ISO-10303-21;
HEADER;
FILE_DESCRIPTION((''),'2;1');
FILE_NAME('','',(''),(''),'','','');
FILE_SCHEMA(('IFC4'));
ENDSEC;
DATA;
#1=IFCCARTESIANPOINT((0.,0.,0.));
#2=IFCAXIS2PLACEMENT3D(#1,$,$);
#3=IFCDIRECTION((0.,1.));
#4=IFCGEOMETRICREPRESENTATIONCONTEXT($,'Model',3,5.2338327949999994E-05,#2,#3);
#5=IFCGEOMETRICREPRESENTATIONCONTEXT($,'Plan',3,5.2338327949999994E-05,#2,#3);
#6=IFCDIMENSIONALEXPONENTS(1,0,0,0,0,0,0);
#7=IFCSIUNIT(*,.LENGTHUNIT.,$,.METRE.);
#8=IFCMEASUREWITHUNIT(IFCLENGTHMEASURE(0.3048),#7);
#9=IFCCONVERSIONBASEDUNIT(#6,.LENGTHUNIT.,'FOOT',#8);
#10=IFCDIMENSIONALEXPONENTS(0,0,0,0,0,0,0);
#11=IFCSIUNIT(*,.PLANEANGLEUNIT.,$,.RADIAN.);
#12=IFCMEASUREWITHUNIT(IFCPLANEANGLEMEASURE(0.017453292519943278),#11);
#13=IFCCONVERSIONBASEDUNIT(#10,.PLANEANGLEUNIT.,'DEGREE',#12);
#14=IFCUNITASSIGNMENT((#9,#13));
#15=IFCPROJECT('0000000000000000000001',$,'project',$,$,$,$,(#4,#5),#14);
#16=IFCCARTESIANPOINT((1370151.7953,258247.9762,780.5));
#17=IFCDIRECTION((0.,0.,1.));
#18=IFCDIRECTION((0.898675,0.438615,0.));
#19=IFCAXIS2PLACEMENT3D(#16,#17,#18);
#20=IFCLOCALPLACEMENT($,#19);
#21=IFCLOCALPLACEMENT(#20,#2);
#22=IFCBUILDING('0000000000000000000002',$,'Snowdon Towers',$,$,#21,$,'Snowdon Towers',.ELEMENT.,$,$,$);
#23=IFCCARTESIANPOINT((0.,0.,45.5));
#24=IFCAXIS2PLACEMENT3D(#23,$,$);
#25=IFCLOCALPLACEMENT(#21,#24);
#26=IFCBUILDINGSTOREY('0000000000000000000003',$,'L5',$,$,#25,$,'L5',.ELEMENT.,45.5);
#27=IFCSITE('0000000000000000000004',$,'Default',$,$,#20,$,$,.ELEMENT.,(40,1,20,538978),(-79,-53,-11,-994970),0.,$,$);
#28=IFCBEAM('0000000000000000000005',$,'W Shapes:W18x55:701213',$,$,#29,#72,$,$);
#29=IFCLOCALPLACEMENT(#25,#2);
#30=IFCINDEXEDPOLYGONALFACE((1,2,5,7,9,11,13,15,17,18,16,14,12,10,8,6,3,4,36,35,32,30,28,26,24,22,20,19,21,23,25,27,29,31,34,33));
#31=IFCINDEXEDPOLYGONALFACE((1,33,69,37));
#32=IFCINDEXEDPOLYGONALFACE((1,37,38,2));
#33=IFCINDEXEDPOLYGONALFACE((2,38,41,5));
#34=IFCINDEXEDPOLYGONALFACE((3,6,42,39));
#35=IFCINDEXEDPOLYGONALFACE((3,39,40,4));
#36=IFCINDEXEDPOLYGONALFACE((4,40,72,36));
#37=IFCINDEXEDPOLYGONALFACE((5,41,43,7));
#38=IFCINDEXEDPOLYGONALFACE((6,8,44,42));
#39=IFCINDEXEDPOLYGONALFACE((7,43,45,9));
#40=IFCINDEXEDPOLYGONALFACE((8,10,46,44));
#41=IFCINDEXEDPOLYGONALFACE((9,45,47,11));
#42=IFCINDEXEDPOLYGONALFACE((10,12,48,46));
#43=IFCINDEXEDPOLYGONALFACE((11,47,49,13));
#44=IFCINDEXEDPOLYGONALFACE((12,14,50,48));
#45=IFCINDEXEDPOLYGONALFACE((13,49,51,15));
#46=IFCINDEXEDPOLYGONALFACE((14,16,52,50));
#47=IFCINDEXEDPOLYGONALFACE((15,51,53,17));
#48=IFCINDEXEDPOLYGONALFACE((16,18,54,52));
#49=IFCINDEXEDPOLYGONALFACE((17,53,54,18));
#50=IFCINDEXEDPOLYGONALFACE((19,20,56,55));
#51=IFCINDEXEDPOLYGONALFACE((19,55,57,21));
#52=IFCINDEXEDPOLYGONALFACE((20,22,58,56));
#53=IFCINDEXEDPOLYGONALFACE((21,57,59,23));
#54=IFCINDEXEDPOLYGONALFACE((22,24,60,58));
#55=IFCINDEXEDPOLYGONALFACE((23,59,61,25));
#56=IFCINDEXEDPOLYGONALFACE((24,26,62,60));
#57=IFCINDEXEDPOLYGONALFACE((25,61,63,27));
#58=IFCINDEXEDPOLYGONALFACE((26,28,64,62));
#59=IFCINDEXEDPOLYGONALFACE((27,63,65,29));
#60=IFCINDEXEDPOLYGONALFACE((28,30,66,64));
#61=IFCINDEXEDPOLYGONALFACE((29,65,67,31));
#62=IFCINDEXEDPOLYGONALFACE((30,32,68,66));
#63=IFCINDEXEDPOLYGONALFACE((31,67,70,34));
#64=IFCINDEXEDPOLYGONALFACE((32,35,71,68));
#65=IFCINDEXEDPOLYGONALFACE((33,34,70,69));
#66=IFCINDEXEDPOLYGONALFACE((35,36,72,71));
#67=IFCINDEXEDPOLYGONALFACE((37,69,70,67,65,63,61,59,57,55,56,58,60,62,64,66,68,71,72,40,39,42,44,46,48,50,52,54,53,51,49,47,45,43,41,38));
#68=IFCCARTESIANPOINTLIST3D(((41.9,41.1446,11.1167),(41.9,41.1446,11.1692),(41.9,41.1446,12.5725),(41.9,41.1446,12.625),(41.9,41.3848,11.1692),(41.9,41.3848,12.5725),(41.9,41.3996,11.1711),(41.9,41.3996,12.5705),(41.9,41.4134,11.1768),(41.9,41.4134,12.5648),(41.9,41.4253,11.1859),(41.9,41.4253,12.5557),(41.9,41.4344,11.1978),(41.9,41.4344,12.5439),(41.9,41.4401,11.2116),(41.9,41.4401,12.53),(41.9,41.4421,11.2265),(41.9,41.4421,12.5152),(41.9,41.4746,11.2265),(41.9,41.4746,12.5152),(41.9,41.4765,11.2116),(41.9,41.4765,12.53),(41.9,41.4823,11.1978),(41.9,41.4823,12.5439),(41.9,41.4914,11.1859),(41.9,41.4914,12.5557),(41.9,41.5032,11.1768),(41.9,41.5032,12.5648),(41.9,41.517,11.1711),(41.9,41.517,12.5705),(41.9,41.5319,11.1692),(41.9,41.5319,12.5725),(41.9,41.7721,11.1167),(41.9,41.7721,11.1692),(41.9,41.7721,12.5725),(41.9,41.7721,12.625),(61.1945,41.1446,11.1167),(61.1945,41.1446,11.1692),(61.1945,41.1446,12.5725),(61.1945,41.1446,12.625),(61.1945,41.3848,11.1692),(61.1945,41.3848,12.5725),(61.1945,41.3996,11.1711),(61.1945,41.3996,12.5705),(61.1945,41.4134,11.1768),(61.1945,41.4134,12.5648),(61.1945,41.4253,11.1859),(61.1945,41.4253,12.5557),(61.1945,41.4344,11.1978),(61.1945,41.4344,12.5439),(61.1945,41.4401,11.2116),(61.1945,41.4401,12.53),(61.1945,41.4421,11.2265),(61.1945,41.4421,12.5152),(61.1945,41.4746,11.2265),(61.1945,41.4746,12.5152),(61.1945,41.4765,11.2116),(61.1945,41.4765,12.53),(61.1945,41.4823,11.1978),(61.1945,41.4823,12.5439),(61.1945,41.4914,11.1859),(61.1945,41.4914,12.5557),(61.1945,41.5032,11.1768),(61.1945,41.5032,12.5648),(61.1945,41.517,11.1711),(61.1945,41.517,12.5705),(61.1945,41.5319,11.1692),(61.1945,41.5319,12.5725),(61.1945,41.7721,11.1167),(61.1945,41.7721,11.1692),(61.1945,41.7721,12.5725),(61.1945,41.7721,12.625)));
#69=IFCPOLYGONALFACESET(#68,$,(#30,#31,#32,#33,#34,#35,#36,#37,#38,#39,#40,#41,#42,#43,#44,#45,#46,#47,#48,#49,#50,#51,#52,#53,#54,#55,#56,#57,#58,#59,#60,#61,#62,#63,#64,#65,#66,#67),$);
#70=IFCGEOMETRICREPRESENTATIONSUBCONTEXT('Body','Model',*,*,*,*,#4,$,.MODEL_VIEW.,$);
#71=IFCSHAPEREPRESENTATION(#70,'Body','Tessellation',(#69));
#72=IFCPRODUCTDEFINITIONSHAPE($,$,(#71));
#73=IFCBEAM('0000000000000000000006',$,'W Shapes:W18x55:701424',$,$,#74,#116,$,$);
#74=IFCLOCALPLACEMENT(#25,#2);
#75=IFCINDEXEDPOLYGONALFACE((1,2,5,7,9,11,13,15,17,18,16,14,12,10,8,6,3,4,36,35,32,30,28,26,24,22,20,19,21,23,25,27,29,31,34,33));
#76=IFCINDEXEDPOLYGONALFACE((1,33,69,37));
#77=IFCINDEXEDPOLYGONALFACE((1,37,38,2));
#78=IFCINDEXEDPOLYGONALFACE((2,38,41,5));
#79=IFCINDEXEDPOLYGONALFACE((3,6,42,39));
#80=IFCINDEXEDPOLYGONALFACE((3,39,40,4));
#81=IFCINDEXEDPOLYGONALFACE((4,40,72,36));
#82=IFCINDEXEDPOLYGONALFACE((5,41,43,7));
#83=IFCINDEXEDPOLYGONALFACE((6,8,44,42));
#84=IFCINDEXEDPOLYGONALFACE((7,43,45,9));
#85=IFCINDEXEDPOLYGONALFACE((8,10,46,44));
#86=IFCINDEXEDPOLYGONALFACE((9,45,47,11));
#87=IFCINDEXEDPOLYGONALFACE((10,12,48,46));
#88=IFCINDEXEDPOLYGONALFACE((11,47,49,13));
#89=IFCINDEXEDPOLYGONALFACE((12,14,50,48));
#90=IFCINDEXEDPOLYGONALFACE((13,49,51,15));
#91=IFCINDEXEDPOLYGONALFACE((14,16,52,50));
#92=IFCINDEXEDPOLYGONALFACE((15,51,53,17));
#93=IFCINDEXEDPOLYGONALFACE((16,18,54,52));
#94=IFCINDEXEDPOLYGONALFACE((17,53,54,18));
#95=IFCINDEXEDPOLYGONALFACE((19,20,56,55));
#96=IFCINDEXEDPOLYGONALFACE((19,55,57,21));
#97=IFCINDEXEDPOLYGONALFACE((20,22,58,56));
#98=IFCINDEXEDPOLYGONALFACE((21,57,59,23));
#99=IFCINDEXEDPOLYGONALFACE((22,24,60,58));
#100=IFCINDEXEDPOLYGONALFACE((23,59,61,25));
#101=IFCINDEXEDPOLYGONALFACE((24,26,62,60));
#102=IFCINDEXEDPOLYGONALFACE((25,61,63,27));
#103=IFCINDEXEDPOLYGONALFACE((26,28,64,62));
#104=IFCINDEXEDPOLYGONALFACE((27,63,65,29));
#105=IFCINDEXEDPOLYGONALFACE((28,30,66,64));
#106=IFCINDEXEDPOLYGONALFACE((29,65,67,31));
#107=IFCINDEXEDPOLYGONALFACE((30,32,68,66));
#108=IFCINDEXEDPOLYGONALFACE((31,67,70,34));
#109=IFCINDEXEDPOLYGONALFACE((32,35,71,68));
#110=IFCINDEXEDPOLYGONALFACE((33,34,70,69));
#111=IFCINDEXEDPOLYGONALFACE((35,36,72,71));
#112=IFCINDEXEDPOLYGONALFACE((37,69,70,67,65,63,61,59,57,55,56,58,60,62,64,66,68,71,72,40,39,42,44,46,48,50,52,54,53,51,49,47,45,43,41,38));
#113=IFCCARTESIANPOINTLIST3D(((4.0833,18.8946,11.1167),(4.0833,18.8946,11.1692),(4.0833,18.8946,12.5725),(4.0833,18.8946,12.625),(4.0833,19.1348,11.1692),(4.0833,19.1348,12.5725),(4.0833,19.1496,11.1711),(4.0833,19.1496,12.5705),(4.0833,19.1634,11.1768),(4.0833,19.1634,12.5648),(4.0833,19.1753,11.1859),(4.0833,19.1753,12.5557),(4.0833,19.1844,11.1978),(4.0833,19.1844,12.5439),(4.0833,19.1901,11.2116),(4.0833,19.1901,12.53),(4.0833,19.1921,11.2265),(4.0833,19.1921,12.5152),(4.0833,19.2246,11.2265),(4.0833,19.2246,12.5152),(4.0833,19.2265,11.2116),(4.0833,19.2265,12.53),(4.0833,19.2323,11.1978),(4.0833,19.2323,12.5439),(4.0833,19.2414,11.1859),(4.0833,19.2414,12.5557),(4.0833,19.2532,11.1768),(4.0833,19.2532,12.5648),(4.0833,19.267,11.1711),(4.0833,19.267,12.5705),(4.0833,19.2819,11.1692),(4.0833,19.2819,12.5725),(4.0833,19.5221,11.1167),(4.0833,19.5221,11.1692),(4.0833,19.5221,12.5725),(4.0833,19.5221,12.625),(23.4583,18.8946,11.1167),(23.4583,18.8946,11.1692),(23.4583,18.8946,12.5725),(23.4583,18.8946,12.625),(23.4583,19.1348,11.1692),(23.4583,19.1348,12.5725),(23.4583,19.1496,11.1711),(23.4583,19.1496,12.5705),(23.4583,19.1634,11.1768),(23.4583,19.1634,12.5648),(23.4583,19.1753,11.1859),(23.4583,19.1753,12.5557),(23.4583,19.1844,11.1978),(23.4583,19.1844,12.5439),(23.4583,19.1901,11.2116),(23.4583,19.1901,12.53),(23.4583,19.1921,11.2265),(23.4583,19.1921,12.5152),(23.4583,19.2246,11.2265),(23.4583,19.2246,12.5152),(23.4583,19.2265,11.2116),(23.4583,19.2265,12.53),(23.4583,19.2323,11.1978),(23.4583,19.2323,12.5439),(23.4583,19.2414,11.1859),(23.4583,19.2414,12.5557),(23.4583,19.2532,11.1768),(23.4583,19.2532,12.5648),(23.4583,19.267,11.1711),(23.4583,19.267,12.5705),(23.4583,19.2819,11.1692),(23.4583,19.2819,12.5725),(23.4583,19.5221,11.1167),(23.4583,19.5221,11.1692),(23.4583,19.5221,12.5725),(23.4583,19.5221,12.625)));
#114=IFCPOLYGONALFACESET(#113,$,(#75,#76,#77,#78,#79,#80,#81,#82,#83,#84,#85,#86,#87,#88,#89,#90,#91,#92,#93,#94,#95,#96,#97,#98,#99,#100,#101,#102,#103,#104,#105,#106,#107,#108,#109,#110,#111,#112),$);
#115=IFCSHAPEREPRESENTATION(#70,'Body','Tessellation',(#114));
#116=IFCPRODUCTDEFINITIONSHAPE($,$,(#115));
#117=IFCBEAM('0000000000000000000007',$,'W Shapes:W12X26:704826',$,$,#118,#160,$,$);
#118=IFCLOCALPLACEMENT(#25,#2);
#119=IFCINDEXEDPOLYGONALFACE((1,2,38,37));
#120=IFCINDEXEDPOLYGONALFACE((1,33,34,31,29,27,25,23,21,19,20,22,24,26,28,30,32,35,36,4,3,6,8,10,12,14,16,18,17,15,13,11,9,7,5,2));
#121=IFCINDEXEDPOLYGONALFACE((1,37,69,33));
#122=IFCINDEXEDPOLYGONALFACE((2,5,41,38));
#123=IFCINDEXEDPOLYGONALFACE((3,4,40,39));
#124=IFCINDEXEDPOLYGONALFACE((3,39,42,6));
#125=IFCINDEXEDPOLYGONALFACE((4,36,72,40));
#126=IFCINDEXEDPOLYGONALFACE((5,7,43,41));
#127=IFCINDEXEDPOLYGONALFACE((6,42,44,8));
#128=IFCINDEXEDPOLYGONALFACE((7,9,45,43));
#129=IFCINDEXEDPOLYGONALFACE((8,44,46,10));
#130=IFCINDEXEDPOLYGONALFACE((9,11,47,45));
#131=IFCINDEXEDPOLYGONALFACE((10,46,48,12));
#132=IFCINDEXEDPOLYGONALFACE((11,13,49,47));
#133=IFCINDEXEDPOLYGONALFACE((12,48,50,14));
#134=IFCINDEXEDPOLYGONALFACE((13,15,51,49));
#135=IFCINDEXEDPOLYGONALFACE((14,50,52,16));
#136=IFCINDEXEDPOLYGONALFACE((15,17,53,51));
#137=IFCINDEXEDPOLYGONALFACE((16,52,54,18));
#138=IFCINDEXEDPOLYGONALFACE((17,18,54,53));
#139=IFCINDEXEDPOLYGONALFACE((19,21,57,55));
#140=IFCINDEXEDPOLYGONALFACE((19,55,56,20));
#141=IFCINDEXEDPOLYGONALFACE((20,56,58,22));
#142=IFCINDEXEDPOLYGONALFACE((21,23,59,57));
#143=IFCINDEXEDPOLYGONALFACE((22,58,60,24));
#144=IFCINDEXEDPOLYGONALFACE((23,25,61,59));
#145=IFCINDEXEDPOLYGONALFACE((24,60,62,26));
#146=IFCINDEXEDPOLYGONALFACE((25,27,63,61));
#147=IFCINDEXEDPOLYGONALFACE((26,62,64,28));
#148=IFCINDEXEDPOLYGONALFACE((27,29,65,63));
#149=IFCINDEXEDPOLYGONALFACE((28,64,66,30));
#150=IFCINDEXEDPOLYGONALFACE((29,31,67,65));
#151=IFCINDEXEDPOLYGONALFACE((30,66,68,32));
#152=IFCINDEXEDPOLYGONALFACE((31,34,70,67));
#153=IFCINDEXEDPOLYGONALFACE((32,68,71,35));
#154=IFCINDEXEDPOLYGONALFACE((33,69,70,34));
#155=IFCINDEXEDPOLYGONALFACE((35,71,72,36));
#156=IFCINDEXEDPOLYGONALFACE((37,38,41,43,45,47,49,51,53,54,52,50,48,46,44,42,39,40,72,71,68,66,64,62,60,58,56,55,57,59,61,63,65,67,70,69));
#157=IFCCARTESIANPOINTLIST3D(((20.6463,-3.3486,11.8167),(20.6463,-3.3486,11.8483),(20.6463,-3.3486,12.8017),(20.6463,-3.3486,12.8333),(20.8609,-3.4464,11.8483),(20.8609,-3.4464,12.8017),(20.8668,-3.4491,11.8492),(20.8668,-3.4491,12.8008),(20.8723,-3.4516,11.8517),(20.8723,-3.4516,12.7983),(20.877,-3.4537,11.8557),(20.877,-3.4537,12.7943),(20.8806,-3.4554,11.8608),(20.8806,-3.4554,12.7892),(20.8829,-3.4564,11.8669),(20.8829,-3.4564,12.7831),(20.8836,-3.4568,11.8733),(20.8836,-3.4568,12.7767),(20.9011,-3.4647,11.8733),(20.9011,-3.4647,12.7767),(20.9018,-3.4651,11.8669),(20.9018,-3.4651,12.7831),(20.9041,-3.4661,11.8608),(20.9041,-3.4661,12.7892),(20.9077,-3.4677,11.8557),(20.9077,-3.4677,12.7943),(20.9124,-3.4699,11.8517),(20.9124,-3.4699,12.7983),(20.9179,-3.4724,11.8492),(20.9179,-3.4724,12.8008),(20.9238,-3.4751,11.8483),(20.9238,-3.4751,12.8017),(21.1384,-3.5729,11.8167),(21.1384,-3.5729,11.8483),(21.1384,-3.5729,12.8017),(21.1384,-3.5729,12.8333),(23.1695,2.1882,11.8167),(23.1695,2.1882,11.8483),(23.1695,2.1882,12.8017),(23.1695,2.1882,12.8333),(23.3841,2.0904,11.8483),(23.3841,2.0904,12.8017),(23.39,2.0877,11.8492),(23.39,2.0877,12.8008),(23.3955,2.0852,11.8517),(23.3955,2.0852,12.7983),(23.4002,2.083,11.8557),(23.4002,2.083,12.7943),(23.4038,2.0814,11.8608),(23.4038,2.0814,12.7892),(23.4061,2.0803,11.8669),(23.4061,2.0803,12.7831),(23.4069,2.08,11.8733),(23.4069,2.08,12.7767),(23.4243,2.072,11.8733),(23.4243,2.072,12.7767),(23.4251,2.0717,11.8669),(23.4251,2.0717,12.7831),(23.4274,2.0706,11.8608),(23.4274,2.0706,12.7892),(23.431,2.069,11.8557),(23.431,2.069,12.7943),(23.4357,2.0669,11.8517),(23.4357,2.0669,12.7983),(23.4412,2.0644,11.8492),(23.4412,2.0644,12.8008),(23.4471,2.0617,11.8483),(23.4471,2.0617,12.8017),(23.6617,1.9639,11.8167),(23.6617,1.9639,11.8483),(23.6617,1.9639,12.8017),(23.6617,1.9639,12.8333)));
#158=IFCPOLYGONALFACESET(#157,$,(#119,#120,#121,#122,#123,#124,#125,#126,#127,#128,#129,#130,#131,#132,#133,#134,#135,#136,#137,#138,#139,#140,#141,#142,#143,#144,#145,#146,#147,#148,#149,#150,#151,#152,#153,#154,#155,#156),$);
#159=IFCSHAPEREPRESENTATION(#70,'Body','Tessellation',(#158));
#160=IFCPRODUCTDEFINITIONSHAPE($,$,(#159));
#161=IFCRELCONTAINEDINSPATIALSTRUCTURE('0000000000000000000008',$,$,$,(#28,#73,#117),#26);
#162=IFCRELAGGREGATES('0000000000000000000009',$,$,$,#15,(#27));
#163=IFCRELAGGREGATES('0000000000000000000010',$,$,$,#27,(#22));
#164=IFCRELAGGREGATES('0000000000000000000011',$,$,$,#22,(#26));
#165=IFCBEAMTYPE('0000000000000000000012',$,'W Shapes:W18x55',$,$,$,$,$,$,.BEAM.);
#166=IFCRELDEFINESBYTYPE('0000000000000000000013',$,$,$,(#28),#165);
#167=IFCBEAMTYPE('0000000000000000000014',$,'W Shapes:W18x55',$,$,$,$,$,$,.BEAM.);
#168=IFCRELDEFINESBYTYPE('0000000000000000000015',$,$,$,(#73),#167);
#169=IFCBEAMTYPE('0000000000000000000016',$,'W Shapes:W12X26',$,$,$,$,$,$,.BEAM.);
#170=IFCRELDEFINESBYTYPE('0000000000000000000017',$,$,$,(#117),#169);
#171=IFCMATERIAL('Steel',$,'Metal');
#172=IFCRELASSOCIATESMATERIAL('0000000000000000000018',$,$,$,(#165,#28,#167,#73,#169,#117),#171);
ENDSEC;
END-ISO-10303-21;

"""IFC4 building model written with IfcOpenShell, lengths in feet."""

from ifc_helpers import new_model, entity, si_unit, converted_unit, direction, frame, origin, place, context, subcontext, project, spatial, line, arc, indexed_curve, outline, extrude, source, transform, mapped, material, type_object, type_shapes, element, save


model = new_model("IFC4")

# Units and contexts
model_context = context("Model", 3, precision=5.2338327949999994e-05, world=origin(), true_north=direction((0.0, 1.0)))
plan_context = context("Plan", 3, precision=5.2338327949999994e-05, world=origin(), true_north=direction((0.0, 1.0)))
body_context = subcontext(model_context, "Body", "Model", "MODEL_VIEW")
ifc_project = project(units=[converted_unit("LENGTHUNIT", "FOOT", entity("IfcLengthMeasure", 0.3048), si_unit("LENGTHUNIT", "METRE"), dimensions=[1, 0, 0, 0, 0, 0, 0]), converted_unit("PLANEANGLEUNIT", "DEGREE", entity("IfcPlaneAngleMeasure", 0.017453292519943278), si_unit("PLANEANGLEUNIT", "RADIAN"), dimensions=[0, 0, 0, 0, 0, 0, 0])], contexts=[model_context, plan_context])

# Site, building, storey
site_placement = place(None, frame((1370151.7953, 258247.9762, 780.5), z_axis=(0.0, 0.0, 1.0), x_axis=(0.898675, 0.438615, 0.0)))
site = spatial("IfcSite", under=ifc_project, at=site_placement, Name="Default", CompositionType="ELEMENT", RefLatitude=(40, 1, 20, 538978), RefLongitude=(-79, -53, -11, -994970), RefElevation=0.0)
building_placement = place(site_placement, origin())
building = spatial("IfcBuilding", under=site, at=building_placement, Name="Snowdon Towers", LongName="Snowdon Towers", CompositionType="ELEMENT")
storey_placement = place(building_placement, frame((0.0, 0.0, 45.5)))
storey = spatial("IfcBuildingStorey", under=building, at=storey_placement, Name="L5", LongName="L5", CompositionType="ELEMENT", Elevation=45.5)

# Shared definitions
ifc_material = material(Name="Steel", Category="Metal")

# Beams
beam_type_1 = type_object("IfcBeamType", Name="W Shapes:W18x55", PredefinedType="BEAM", material=ifc_material)
shared_shape_1 = source(origin(), body_context, "Body", "SweptSolid", [
    extrude(outline(indexed_curve([(-0.7542, -0.3138), (-0.7017, -0.3138), (-0.7017, -0.0735), (-0.6849, -0.033), (-0.6444, -0.0162), (0.6444, -0.0162), (0.6849, -0.033), (0.7017, -0.0735), (0.7017, -0.3138), (0.7542, -0.3138), (0.7542, 0.3138), (0.7017, 0.3138), (0.7017, 0.0735), (0.6849, 0.033), (0.6444, 0.0163), (-0.6444, 0.0163), (-0.6849, 0.033), (-0.7017, 0.0735), (-0.7017, 0.3137), (-0.7542, 0.3137)], segments=[line(1, 2, 3), arc(3, 4, 5), line(5, 6), arc(6, 7, 8), line(8, 9, 10, 11, 12, 13), arc(13, 14, 15), line(15, 16), arc(16, 17, 18), line(18, 19, 20, 1)], self_intersect=False)), frame((-9.9242, 0.0, 0.0), z_axis=(1.0, 0.0, 0.0), x_axis=(0.0, 0.0, -1.0)), (0.0, 0.0, 1.0), 19.2945),
])
type_shapes(beam_type_1, [shared_shape_1])
beam_1_placement = place(storey_placement, frame((51.8242, 41.4583, 11.8708)))
element("IfcBeam", 1, at=beam_1_placement, inside=storey, type_object=beam_type_1, material=ifc_material, Name="W Shapes:W18x55:701213", context=body_context, shape_type="MappedRepresentation", body=[
    mapped(shared_shape_1, transform((0.0, 0.0, 0.0), scale=1.0)),
])
beam_type_2 = type_object("IfcBeamType", Name="W Shapes:W18x55", PredefinedType="BEAM", material=ifc_material)
shared_shape_2 = source(origin(), body_context, "Body", "SweptSolid", [
    extrude(outline(indexed_curve([(-0.7542, -0.3138), (-0.7017, -0.3138), (-0.7017, -0.0735), (-0.6849, -0.033), (-0.6444, -0.0162), (0.6444, -0.0162), (0.6849, -0.033), (0.7017, -0.0735), (0.7017, -0.3138), (0.7542, -0.3138), (0.7542, 0.3138), (0.7017, 0.3138), (0.7017, 0.0735), (0.6849, 0.033), (0.6444, 0.0163), (-0.6444, 0.0163), (-0.6849, 0.033), (-0.7017, 0.0735), (-0.7017, 0.3137), (-0.7542, 0.3137)], segments=[line(1, 2, 3), arc(3, 4, 5), line(5, 6), arc(6, 7, 8), line(8, 9, 10, 11, 12, 13), arc(13, 14, 15), line(15, 16), arc(16, 17, 18), line(18, 19, 20, 1)], self_intersect=False)), frame((-9.9167, 0.0, 0.0), z_axis=(1.0, 0.0, 0.0), x_axis=(0.0, 0.0, -1.0)), (0.0, 0.0, 1.0), 19.375),
])
type_shapes(beam_type_2, [shared_shape_2])
beam_2_placement = place(storey_placement, frame((14.0, 19.2083, 11.8708)))
element("IfcBeam", 2, at=beam_2_placement, inside=storey, type_object=beam_type_2, material=ifc_material, Name="W Shapes:W18x55:701424", context=body_context, shape_type="MappedRepresentation", body=[
    mapped(shared_shape_2, transform((0.0, 0.0, 0.0), scale=1.0)),
])
beam_type_3 = type_object("IfcBeamType", Name="W Shapes:W12X26", PredefinedType="BEAM", material=ifc_material)
shared_shape_3 = source(origin(), body_context, "Body", "SweptSolid", [
    extrude(outline(indexed_curve([(-0.5083, -0.2704), (-0.4767, -0.2704), (-0.4767, -0.0346), (-0.4693, -0.0169), (-0.4517, -0.0096), (0.4517, -0.0096), (0.4693, -0.0169), (0.4767, -0.0346), (0.4767, -0.2704), (0.5083, -0.2704), (0.5083, 0.2704), (0.4767, 0.2704), (0.4767, 0.0346), (0.4693, 0.0169), (0.4517, 0.0096), (-0.4517, 0.0096), (-0.4693, 0.0169), (-0.4767, 0.0346), (-0.4767, 0.2704), (-0.5083, 0.2704)], segments=[line(1, 2, 3), arc(3, 4, 5), line(5, 6), arc(6, 7, 8), line(8, 9, 10, 11, 12, 13), arc(13, 14, 15), line(15, 16), arc(16, 17, 18), line(18, 19, 20, 1)], self_intersect=False)), frame((-3.0878, 0.0, 0.0), z_axis=(1.0, 0.0, 0.0), x_axis=(0.0, 0.0, -1.0)), (0.0, 0.0, 1.0), 6.0846),
])
type_shapes(beam_type_3, [shared_shape_3])
beam_3_placement = place(storey_placement, frame((22.1728, -0.651, 12.325), z_axis=(0.0, 0.0, 1.0), x_axis=(0.414693, 0.909961, 0.0)))
element("IfcBeam", 3, at=beam_3_placement, inside=storey, type_object=beam_type_3, material=ifc_material, Name="W Shapes:W12X26:704826", context=body_context, shape_type="MappedRepresentation", body=[
    mapped(shared_shape_3, transform((0.0, 0.0, 0.0), scale=1.0)),
])

save(model, "model.ifc")
